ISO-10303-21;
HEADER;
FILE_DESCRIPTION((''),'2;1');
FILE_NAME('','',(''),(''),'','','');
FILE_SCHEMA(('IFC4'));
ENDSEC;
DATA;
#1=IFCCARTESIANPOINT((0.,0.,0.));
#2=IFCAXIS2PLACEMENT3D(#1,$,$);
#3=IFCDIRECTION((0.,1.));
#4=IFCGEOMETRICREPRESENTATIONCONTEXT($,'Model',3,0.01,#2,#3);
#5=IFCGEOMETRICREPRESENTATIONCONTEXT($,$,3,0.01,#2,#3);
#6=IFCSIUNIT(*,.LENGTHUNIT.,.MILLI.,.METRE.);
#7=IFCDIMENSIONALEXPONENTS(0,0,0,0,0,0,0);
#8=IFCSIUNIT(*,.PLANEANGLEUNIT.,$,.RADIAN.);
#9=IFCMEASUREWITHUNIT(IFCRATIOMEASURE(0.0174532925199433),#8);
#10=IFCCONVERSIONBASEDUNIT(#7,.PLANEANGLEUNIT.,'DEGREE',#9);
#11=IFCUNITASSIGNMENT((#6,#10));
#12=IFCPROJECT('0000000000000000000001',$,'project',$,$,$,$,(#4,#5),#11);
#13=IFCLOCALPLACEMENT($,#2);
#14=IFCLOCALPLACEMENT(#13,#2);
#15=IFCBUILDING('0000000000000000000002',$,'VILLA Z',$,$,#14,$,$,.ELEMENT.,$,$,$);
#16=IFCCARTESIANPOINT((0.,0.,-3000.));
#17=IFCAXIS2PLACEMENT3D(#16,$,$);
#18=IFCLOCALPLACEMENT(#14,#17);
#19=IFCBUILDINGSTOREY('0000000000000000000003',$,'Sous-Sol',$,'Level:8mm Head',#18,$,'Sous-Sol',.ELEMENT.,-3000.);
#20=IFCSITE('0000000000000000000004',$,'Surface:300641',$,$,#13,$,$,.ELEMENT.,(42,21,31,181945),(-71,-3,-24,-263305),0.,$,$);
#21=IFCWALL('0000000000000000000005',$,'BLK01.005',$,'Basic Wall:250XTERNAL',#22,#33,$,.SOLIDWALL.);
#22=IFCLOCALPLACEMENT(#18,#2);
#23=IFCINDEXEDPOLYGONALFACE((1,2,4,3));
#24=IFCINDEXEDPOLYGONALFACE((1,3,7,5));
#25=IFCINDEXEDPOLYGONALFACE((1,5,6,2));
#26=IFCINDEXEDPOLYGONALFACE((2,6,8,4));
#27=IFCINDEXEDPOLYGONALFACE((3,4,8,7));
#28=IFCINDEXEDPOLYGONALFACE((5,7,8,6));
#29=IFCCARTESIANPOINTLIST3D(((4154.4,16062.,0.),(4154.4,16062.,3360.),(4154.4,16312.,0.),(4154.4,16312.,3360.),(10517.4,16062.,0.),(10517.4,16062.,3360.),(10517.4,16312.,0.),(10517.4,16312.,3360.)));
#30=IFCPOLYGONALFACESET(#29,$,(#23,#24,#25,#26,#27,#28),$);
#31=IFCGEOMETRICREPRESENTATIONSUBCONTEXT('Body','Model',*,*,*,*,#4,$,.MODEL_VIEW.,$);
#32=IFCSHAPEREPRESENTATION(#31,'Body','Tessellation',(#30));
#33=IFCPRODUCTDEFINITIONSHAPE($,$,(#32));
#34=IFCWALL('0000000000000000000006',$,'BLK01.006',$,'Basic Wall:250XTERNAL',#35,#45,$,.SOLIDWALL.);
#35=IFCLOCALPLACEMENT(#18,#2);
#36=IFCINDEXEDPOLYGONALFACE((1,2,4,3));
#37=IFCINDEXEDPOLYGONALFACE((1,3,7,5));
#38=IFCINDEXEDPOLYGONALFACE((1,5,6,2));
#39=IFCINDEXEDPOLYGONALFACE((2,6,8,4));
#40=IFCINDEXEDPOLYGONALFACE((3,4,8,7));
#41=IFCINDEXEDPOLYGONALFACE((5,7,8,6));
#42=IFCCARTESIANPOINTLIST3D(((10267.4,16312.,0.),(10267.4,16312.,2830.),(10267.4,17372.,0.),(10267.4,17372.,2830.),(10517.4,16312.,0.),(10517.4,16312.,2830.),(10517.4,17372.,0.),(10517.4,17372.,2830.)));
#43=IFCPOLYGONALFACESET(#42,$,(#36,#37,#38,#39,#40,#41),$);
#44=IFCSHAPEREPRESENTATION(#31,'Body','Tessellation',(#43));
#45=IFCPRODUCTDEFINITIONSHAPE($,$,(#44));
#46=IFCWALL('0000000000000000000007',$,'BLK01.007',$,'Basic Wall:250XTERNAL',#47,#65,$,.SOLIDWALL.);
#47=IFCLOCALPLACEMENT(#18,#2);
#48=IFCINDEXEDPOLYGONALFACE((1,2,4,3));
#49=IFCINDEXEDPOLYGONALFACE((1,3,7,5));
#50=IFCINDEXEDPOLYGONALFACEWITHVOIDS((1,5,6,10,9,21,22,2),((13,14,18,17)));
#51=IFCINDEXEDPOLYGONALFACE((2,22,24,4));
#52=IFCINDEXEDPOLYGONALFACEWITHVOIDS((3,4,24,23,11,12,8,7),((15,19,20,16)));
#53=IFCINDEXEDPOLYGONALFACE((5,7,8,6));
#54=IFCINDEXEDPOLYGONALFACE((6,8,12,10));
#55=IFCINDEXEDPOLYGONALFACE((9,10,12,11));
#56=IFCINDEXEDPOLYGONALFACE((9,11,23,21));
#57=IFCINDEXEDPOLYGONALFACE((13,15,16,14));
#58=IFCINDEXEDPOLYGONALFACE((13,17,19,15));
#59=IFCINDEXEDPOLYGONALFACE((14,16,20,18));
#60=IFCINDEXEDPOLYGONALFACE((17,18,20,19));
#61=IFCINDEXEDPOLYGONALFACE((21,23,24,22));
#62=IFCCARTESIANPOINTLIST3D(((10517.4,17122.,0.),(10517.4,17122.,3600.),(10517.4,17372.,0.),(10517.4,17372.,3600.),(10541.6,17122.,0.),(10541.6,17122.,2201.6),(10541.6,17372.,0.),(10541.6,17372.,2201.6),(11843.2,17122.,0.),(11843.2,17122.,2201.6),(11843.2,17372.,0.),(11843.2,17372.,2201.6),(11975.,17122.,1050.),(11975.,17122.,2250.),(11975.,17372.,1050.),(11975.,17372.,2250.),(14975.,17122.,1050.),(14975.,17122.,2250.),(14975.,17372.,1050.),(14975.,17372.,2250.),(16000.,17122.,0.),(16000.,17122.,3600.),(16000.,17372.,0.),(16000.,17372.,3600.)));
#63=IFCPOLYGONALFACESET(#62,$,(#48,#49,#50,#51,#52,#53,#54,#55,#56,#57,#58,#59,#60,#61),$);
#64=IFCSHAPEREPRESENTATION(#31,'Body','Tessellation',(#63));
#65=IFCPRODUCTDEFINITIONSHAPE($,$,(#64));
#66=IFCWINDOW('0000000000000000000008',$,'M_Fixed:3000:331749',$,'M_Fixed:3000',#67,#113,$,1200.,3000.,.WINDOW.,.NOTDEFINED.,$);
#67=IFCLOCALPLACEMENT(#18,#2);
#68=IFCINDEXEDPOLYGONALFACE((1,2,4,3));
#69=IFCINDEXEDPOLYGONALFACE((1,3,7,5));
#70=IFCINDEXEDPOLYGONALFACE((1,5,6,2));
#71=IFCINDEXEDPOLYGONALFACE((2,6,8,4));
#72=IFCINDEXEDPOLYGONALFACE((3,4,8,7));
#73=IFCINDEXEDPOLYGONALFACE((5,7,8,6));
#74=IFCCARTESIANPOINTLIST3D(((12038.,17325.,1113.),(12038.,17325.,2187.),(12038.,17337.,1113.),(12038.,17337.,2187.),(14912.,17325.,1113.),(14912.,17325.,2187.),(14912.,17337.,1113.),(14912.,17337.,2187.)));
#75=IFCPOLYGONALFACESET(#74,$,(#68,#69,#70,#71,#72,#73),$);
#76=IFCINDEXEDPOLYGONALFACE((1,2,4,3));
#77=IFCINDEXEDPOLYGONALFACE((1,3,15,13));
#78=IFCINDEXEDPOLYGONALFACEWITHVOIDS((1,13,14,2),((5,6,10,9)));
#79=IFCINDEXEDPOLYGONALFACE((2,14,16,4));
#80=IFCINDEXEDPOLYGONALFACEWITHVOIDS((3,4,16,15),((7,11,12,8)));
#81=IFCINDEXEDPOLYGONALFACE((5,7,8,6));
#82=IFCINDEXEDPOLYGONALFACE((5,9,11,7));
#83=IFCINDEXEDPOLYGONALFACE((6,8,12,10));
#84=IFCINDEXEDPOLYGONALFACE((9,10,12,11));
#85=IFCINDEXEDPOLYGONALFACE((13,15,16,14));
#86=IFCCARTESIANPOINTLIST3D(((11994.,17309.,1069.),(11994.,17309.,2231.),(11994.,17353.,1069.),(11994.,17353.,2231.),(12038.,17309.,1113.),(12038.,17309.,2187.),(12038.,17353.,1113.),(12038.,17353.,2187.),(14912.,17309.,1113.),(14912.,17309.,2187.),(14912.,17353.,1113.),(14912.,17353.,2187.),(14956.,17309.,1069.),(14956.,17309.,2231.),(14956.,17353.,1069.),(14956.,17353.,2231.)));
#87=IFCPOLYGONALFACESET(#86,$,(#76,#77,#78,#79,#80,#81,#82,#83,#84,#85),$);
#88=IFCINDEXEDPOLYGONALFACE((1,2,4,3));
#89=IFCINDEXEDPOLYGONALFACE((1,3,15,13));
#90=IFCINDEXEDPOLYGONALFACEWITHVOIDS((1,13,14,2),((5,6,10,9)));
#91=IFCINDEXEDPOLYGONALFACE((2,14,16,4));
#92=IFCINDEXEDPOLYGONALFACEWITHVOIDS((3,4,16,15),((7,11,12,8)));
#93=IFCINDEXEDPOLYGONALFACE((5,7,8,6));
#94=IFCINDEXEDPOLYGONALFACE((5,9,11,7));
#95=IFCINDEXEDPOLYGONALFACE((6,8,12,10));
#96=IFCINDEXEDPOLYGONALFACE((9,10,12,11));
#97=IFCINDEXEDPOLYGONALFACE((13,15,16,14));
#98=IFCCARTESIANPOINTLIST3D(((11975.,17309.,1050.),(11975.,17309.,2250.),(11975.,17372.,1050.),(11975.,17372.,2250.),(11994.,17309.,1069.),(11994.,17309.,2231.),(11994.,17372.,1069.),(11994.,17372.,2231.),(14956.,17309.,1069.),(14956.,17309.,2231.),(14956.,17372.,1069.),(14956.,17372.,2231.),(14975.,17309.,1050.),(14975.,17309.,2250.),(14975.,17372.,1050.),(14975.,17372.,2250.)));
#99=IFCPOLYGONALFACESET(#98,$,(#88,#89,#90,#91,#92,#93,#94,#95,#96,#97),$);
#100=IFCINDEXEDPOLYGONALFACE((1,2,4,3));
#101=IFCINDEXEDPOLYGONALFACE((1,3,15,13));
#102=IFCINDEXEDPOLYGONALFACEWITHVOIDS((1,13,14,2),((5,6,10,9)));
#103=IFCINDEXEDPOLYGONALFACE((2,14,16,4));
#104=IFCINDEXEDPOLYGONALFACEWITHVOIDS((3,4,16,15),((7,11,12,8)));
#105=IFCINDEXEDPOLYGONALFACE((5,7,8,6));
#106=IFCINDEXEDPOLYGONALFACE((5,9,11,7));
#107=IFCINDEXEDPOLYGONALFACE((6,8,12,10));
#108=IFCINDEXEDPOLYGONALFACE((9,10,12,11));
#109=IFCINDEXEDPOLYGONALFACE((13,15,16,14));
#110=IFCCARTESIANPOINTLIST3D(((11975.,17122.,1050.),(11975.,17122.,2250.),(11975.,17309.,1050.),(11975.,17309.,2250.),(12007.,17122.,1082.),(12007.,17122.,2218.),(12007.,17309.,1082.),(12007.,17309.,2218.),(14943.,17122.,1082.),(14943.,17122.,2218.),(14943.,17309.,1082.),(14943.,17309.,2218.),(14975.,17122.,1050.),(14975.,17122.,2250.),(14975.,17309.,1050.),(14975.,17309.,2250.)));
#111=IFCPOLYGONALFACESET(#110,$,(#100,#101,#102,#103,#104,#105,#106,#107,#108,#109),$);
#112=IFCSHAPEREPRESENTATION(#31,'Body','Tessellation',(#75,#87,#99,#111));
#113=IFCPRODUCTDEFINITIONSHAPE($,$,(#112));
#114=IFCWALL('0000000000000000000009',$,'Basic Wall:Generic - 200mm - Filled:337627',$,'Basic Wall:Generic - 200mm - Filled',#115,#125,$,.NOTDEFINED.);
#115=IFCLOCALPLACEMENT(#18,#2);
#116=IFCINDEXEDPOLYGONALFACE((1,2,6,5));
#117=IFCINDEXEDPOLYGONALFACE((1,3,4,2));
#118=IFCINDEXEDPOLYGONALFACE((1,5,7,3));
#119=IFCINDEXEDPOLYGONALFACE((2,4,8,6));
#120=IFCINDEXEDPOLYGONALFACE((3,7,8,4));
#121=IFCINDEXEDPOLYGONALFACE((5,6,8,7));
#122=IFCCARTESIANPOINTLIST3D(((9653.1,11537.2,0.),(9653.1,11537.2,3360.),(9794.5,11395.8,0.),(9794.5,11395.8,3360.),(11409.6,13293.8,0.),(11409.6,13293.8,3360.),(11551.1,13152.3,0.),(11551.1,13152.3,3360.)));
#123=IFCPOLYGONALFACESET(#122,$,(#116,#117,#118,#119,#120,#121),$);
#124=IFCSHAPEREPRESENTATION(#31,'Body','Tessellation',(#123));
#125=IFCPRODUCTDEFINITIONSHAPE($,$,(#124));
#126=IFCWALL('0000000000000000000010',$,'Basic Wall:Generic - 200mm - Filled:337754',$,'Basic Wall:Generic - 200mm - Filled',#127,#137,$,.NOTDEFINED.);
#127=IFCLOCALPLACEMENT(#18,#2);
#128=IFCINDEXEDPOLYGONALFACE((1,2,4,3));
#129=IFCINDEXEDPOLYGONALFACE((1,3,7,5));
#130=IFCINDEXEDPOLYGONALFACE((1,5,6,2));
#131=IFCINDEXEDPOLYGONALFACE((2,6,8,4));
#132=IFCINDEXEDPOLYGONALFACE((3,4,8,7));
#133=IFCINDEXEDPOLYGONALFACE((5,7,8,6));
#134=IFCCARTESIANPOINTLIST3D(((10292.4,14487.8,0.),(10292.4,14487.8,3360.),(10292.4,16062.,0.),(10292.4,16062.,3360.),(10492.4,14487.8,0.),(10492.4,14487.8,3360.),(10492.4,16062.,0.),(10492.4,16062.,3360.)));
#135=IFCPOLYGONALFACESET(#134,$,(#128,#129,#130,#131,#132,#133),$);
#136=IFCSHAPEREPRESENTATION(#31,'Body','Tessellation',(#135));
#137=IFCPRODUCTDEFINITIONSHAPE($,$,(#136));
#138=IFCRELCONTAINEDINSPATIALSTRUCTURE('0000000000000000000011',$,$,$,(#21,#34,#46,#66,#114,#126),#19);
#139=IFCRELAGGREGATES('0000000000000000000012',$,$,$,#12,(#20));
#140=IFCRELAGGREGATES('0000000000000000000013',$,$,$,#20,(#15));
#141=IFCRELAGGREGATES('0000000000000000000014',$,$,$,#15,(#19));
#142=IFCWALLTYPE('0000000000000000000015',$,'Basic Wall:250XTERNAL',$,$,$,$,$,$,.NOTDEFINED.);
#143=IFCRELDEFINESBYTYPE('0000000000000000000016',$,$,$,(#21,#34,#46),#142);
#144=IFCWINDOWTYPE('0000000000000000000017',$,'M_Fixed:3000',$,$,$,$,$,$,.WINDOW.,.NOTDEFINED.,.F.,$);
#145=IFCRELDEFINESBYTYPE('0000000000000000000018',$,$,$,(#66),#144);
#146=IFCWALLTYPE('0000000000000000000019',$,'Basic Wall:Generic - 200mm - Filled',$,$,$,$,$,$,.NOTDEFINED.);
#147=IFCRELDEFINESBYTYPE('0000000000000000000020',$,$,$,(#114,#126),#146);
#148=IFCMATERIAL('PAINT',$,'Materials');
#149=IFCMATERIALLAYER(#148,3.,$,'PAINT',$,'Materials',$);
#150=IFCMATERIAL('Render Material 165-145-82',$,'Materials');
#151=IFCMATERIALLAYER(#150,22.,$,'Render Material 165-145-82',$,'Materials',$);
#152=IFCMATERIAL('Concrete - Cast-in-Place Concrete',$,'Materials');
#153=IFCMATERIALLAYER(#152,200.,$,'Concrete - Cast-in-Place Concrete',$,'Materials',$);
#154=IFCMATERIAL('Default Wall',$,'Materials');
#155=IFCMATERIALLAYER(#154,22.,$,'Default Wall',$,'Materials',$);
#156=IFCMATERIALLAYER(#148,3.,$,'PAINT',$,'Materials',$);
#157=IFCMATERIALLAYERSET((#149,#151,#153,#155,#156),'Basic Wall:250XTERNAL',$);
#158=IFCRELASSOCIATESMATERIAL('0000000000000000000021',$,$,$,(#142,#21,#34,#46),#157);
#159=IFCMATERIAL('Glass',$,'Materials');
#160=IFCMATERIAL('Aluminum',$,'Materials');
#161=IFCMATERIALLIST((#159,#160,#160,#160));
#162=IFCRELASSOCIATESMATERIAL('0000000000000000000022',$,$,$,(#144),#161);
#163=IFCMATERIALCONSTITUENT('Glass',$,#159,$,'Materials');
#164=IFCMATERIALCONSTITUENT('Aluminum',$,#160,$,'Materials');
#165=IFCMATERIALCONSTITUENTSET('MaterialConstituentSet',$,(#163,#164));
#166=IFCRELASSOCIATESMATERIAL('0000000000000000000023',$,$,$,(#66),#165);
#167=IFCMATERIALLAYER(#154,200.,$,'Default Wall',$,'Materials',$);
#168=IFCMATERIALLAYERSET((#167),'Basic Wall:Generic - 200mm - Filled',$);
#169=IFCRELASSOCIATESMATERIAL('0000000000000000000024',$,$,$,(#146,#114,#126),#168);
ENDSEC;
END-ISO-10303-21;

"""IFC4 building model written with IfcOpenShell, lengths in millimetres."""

from ifc_helpers import new_model, entity, si_unit, converted_unit, direction, frame, frame_2d, origin, place, context, subcontext, project, spatial, polyline, rectangle, outline, extrude, clip, bounded_halfspace, source, transform, mapped, material, material_list, layer, layer_set, layer_usage, constituent, constituent_set, type_object, type_shapes, element, fill, save


model = new_model("IFC4")

# Units and contexts
model_context = context("Model", 3, precision=0.01, world=origin(), true_north=direction((0.0, 1.0)))
context_of_model = context(None, 3, precision=0.01, world=origin(), true_north=direction((0.0, 1.0)))
body_context = subcontext(model_context, "Body", "Model", "MODEL_VIEW")
ifc_project = project(units=[si_unit("LENGTHUNIT", "METRE", prefix="MILLI"), converted_unit("PLANEANGLEUNIT", "DEGREE", entity("IfcRatioMeasure", 0.0174532925199433), si_unit("PLANEANGLEUNIT", "RADIAN"), dimensions=[0, 0, 0, 0, 0, 0, 0])], contexts=[model_context, context_of_model])

# Site, building, storey
site_placement = place(None, origin())
site = spatial("IfcSite", under=ifc_project, at=site_placement, Name="Surface:300641", CompositionType="ELEMENT", RefLatitude=(42, 21, 31, 181945), RefLongitude=(-71, -3, -24, -263305), RefElevation=0.0)
building_placement = place(site_placement, origin())
building = spatial("IfcBuilding", under=site, at=building_placement, Name="VILLA Z", CompositionType="ELEMENT")
storey_placement = place(building_placement, frame((0.0, 0.0, -3000.0)))
storey = spatial("IfcBuildingStorey", under=building, at=storey_placement, Name="Sous-Sol", ObjectType="Level:8mm Head", LongName="Sous-Sol", CompositionType="ELEMENT", Elevation=-3000.0)

# Walls
ifc_material_1 = material(Name="PAINT", Category="Materials")
ifc_layer_1 = layer(ifc_material_1, 3.0, Name="PAINT", Category="Materials")
ifc_material_2 = material(Name="Render Material 165-145-82", Category="Materials")
ifc_layer_2 = layer(ifc_material_2, 22.0, Name="Render Material 165-145-82", Category="Materials")
ifc_material_3 = material(Name="Concrete - Cast-in-Place Concrete", Category="Materials")
ifc_layer_3 = layer(ifc_material_3, 200.0, Name="Concrete - Cast-in-Place Concrete", Category="Materials")
ifc_material_4 = material(Name="Default Wall", Category="Materials")
ifc_layer_4 = layer(ifc_material_4, 22.0, Name="Default Wall", Category="Materials")
ifc_layer_5 = layer(ifc_material_1, 3.0, Name="PAINT", Category="Materials")
ifc_layer_set_1 = layer_set([ifc_layer_1, ifc_layer_2, ifc_layer_3, ifc_layer_4, ifc_layer_5], Name="Basic Wall:250XTERNAL")
ifc_layer_usage_1 = layer_usage(ifc_layer_set_1, "AXIS2", "NEGATIVE", 125.0)
wall_type_1 = type_object("IfcWallType", Name="Basic Wall:250XTERNAL", PredefinedType="NOTDEFINED", material=ifc_layer_set_1)
wall_1_placement = place(storey_placement, frame((4154.4, 16187.0, 0.0)))
element("IfcWall", 1, at=wall_1_placement, inside=storey, type_object=wall_type_1, material=ifc_layer_usage_1, Name="BLK01.005", ObjectType="Basic Wall:250XTERNAL", PredefinedType="SOLIDWALL", context=body_context, shape_type="Clipping", body=[
    clip(extrude(rectangle(XDim=6362.9, YDim=250.0, at=frame_2d((3181.5, 0.0), x_axis=(-1.0, 0.0))), origin(), (0.0, 0.0, 1.0), 3360.0), bounded_halfspace(frame((0.0, -125.0, 3360.0), z_axis=(0.0, 0.0, -1.0), x_axis=(0.0, -1.0, 0.0)), True, frame((0.0, -125.0, 3360.0)), polyline([(0.0, 0.0), (6137.9, 0.0), (6337.9, 0.0), (6362.9, 0.0), (6362.9, 250.0), (6112.9, 250.0), (0.0, 250.0), (0.0, 0.0)]))),
])
ifc_layer_usage_2 = layer_usage(ifc_layer_set_1, "AXIS2", "NEGATIVE", 125.0)
wall_2_placement = place(storey_placement, frame((10392.4, 16312.0, 0.0), z_axis=(0.0, 0.0, 1.0), x_axis=(0.0, 1.0, 0.0)))
element("IfcWall", 2, at=wall_2_placement, inside=storey, type_object=wall_type_1, material=ifc_layer_usage_2, Name="BLK01.006", ObjectType="Basic Wall:250XTERNAL", PredefinedType="SOLIDWALL", context=body_context, shape_type="SweptSolid", body=[
    extrude(rectangle(XDim=1060.0, YDim=250.0, at=frame_2d((530.0, 0.0), x_axis=(-1.0, 0.0))), origin(), (0.0, 0.0, 1.0), 2830.0),
])

# Wall, openings, window
ifc_layer_usage_3 = layer_usage(ifc_layer_set_1, "AXIS2", "NEGATIVE", 125.0)
wall_3_placement = place(storey_placement, frame((10517.4, 17247.0, 0.0)))
wall_3 = element("IfcWall", 3, at=wall_3_placement, inside=storey, type_object=wall_type_1, material=ifc_layer_usage_3, Name="BLK01.007", ObjectType="Basic Wall:250XTERNAL", PredefinedType="SOLIDWALL", context=body_context, shape_type="SweptSolid", body=[
    extrude(rectangle(XDim=5482.6, YDim=250.0, at=frame_2d((2741.3, 0.0), x_axis=(-1.0, 0.0))), origin(), (0.0, 0.0, 1.0), 3600.0),
])
opening_1_placement = place(wall_3_placement, frame((24.2, -125.0, 0.0)))
element("IfcOpeningElement", 4, at=opening_1_placement, cuts=wall_3, ObjectType="Opening", PredefinedType="OPENING", context=body_context, shape_type="SweptSolid", body=[
    extrude(rectangle(XDim=2201.6, YDim=1301.6, at=frame_2d((1100.8, 650.8), x_axis=(1.0, 0.0))), frame((0.0, 0.0, 0.0), z_axis=(0.0, 1.0, 0.0), x_axis=(0.0, 0.0, 1.0)), (0.0, 0.0, 1.0), 250.0),
])
opening_2_placement = place(wall_3_placement, frame((1457.6, -125.0, 1050.0)))
opening_2 = element("IfcOpeningElement", 5, at=opening_2_placement, cuts=wall_3, ObjectType="Opening", PredefinedType="OPENING", context=body_context, shape_type="SweptSolid", body=[
    extrude(rectangle(XDim=1200.0, YDim=3000.0, at=frame_2d((600.0, 1500.0), x_axis=(1.0, 0.0))), frame((0.0, 0.0, 0.0), z_axis=(0.0, 1.0, 0.0), x_axis=(0.0, 0.0, 1.0)), (0.0, 0.0, 1.0), 250.0),
])
ifc_material_5 = material(Name="Glass", Category="Materials")
ifc_constituent_1 = constituent(ifc_material_5, Name="Glass", Category="Materials")
ifc_material_6 = material(Name="Aluminum", Category="Materials")
ifc_constituent_2 = constituent(ifc_material_6, Name="Aluminum", Category="Materials")
ifc_constituent_set_1 = constituent_set(constituents=[ifc_constituent_1, ifc_constituent_2], Name="MaterialConstituentSet")
ifc_material_list_1 = material_list([ifc_material_5, ifc_material_6, ifc_material_6, ifc_material_6])
window_type = type_object("IfcWindowType", Name="M_Fixed:3000", ParameterTakesPrecedence=False, PartitioningType="NOTDEFINED", PredefinedType="WINDOW", material=ifc_material_list_1)
shared_shape_1 = source(origin(), body_context, "Body", "SweptSolid", [
    extrude(rectangle(XDim=12.0, YDim=2874.0, at=frame_2d((0.0, 0.0), x_axis=(1.0, 0.0))), frame((1500.0, 209.0, 63.0), z_axis=(0.0, 0.0, 1.0), x_axis=(0.0, -1.0, 0.0)), (0.0, 0.0, 1.0), 1074.0),
    extrude(outline(polyline([(-1481.0, -581.0), (1481.0, -581.0), (1481.0, 581.0), (-1481.0, 581.0), (-1481.0, -581.0)]), holes=[polyline([(-1437.0, -537.0), (-1437.0, 537.0), (1437.0, 537.0), (1437.0, -537.0), (-1437.0, -537.0)])]), frame((1500.0, 187.0, 600.0), z_axis=(0.0, 1.0, 0.0), x_axis=(1.0, 0.0, 0.0)), (0.0, 0.0, 1.0), 44.0),
    extrude(outline(polyline([(-1500.0, -600.0), (1500.0, -600.0), (1500.0, 600.0), (-1500.0, 600.0), (-1500.0, -600.0)]), holes=[polyline([(-1481.0, -581.0), (-1481.0, 581.0), (1481.0, 581.0), (1481.0, -581.0), (-1481.0, -581.0)])]), frame((1500.0, 187.0, 600.0), z_axis=(0.0, 1.0, 0.0), x_axis=(1.0, 0.0, 0.0)), (0.0, 0.0, 1.0), 63.0),
    extrude(outline(polyline([(-1500.0, -600.0), (1500.0, -600.0), (1500.0, 600.0), (-1500.0, 600.0), (-1500.0, -600.0)]), holes=[polyline([(-1468.0, -568.0), (-1468.0, 568.0), (1468.0, 568.0), (1468.0, -568.0), (-1468.0, -568.0)])]), frame((1500.0, 0.0, 600.0), z_axis=(0.0, 1.0, 0.0), x_axis=(1.0, 0.0, 0.0)), (0.0, 0.0, 1.0), 187.0),
])
type_shapes(window_type, [shared_shape_1])
window_placement = place(opening_2_placement, origin())
window = element("IfcWindow", 6, at=window_placement, inside=storey, type_object=window_type, material=ifc_constituent_set_1, Name="M_Fixed:3000:331749", ObjectType="M_Fixed:3000", OverallHeight=1200.0, OverallWidth=3000.0, PartitioningType="NOTDEFINED", PredefinedType="WINDOW", context=body_context, shape_type="MappedRepresentation", body=[
    mapped(shared_shape_1, transform((0.0, 0.0, 0.0), scale=1.0)),
])
fill(opening_2, window)

# Shared definitions
ifc_layer_6 = layer(ifc_material_4, 200.0, Name="Default Wall", Category="Materials")
ifc_layer_set_2 = layer_set([ifc_layer_6], Name="Basic Wall:Generic - 200mm - Filled")
wall_type_2 = type_object("IfcWallType", Name="Basic Wall:Generic - 200mm - Filled", PredefinedType="NOTDEFINED", material=ifc_layer_set_2)

# Walls
ifc_layer_usage_4 = layer_usage(ifc_layer_set_2, "AXIS2", "NEGATIVE", 100.0)
wall_4_placement = place(storey_placement, frame((11480.3, 13223.0, 0.0), z_axis=(0.0, 0.0, 1.0), x_axis=(-0.707107, -0.707107, 0.0)))
element("IfcWall", 7, at=wall_4_placement, inside=storey, type_object=wall_type_2, material=ifc_layer_usage_4, Name="Basic Wall:Generic - 200mm - Filled:337627", ObjectType="Basic Wall:Generic - 200mm - Filled", PredefinedType="NOTDEFINED", context=body_context, shape_type="Clipping", body=[
    clip(extrude(rectangle(XDim=2484.1, YDim=200.0, at=frame_2d((1242.1, 0.0), x_axis=(-1.0, 0.0))), origin(), (0.0, 0.0, 1.0), 3360.0), bounded_halfspace(frame((0.0, -100.0, 3360.0), z_axis=(0.0, 0.0, -1.0), x_axis=(0.707107, 0.707107, 0.0)), True, frame((0.0, -100.0, 3360.0)), polyline([(0.0, 0.0), (2484.1, 0.0), (2484.1, 200.0), (0.0, 200.0), (0.0, 0.0)]))),
])
ifc_layer_usage_5 = layer_usage(ifc_layer_set_2, "AXIS2", "NEGATIVE", 100.0)
wall_5_placement = place(storey_placement, frame((10392.4, 16062.0, 0.0), z_axis=(0.0, 0.0, 1.0), x_axis=(0.0, -1.0, 0.0)))
element("IfcWall", 8, at=wall_5_placement, inside=storey, type_object=wall_type_2, material=ifc_layer_usage_5, Name="Basic Wall:Generic - 200mm - Filled:337754", ObjectType="Basic Wall:Generic - 200mm - Filled", PredefinedType="NOTDEFINED", context=body_context, shape_type="Clipping", body=[
    clip(extrude(rectangle(XDim=1574.2, YDim=200.0, at=frame_2d((787.1, 0.0), x_axis=(-1.0, 0.0))), origin(), (0.0, 0.0, 1.0), 3360.0), bounded_halfspace(frame((0.0, -100.0, 3360.0), z_axis=(0.0, 0.0, -1.0), x_axis=(1.0, 0.0, 0.0)), True, frame((0.0, -100.0, 3360.0)), polyline([(0.0, 0.0), (1574.2, 0.0), (1574.2, 200.0), (0.0, 200.0), (0.0, 0.0)]))),
])

save(model, "model.ifc")
